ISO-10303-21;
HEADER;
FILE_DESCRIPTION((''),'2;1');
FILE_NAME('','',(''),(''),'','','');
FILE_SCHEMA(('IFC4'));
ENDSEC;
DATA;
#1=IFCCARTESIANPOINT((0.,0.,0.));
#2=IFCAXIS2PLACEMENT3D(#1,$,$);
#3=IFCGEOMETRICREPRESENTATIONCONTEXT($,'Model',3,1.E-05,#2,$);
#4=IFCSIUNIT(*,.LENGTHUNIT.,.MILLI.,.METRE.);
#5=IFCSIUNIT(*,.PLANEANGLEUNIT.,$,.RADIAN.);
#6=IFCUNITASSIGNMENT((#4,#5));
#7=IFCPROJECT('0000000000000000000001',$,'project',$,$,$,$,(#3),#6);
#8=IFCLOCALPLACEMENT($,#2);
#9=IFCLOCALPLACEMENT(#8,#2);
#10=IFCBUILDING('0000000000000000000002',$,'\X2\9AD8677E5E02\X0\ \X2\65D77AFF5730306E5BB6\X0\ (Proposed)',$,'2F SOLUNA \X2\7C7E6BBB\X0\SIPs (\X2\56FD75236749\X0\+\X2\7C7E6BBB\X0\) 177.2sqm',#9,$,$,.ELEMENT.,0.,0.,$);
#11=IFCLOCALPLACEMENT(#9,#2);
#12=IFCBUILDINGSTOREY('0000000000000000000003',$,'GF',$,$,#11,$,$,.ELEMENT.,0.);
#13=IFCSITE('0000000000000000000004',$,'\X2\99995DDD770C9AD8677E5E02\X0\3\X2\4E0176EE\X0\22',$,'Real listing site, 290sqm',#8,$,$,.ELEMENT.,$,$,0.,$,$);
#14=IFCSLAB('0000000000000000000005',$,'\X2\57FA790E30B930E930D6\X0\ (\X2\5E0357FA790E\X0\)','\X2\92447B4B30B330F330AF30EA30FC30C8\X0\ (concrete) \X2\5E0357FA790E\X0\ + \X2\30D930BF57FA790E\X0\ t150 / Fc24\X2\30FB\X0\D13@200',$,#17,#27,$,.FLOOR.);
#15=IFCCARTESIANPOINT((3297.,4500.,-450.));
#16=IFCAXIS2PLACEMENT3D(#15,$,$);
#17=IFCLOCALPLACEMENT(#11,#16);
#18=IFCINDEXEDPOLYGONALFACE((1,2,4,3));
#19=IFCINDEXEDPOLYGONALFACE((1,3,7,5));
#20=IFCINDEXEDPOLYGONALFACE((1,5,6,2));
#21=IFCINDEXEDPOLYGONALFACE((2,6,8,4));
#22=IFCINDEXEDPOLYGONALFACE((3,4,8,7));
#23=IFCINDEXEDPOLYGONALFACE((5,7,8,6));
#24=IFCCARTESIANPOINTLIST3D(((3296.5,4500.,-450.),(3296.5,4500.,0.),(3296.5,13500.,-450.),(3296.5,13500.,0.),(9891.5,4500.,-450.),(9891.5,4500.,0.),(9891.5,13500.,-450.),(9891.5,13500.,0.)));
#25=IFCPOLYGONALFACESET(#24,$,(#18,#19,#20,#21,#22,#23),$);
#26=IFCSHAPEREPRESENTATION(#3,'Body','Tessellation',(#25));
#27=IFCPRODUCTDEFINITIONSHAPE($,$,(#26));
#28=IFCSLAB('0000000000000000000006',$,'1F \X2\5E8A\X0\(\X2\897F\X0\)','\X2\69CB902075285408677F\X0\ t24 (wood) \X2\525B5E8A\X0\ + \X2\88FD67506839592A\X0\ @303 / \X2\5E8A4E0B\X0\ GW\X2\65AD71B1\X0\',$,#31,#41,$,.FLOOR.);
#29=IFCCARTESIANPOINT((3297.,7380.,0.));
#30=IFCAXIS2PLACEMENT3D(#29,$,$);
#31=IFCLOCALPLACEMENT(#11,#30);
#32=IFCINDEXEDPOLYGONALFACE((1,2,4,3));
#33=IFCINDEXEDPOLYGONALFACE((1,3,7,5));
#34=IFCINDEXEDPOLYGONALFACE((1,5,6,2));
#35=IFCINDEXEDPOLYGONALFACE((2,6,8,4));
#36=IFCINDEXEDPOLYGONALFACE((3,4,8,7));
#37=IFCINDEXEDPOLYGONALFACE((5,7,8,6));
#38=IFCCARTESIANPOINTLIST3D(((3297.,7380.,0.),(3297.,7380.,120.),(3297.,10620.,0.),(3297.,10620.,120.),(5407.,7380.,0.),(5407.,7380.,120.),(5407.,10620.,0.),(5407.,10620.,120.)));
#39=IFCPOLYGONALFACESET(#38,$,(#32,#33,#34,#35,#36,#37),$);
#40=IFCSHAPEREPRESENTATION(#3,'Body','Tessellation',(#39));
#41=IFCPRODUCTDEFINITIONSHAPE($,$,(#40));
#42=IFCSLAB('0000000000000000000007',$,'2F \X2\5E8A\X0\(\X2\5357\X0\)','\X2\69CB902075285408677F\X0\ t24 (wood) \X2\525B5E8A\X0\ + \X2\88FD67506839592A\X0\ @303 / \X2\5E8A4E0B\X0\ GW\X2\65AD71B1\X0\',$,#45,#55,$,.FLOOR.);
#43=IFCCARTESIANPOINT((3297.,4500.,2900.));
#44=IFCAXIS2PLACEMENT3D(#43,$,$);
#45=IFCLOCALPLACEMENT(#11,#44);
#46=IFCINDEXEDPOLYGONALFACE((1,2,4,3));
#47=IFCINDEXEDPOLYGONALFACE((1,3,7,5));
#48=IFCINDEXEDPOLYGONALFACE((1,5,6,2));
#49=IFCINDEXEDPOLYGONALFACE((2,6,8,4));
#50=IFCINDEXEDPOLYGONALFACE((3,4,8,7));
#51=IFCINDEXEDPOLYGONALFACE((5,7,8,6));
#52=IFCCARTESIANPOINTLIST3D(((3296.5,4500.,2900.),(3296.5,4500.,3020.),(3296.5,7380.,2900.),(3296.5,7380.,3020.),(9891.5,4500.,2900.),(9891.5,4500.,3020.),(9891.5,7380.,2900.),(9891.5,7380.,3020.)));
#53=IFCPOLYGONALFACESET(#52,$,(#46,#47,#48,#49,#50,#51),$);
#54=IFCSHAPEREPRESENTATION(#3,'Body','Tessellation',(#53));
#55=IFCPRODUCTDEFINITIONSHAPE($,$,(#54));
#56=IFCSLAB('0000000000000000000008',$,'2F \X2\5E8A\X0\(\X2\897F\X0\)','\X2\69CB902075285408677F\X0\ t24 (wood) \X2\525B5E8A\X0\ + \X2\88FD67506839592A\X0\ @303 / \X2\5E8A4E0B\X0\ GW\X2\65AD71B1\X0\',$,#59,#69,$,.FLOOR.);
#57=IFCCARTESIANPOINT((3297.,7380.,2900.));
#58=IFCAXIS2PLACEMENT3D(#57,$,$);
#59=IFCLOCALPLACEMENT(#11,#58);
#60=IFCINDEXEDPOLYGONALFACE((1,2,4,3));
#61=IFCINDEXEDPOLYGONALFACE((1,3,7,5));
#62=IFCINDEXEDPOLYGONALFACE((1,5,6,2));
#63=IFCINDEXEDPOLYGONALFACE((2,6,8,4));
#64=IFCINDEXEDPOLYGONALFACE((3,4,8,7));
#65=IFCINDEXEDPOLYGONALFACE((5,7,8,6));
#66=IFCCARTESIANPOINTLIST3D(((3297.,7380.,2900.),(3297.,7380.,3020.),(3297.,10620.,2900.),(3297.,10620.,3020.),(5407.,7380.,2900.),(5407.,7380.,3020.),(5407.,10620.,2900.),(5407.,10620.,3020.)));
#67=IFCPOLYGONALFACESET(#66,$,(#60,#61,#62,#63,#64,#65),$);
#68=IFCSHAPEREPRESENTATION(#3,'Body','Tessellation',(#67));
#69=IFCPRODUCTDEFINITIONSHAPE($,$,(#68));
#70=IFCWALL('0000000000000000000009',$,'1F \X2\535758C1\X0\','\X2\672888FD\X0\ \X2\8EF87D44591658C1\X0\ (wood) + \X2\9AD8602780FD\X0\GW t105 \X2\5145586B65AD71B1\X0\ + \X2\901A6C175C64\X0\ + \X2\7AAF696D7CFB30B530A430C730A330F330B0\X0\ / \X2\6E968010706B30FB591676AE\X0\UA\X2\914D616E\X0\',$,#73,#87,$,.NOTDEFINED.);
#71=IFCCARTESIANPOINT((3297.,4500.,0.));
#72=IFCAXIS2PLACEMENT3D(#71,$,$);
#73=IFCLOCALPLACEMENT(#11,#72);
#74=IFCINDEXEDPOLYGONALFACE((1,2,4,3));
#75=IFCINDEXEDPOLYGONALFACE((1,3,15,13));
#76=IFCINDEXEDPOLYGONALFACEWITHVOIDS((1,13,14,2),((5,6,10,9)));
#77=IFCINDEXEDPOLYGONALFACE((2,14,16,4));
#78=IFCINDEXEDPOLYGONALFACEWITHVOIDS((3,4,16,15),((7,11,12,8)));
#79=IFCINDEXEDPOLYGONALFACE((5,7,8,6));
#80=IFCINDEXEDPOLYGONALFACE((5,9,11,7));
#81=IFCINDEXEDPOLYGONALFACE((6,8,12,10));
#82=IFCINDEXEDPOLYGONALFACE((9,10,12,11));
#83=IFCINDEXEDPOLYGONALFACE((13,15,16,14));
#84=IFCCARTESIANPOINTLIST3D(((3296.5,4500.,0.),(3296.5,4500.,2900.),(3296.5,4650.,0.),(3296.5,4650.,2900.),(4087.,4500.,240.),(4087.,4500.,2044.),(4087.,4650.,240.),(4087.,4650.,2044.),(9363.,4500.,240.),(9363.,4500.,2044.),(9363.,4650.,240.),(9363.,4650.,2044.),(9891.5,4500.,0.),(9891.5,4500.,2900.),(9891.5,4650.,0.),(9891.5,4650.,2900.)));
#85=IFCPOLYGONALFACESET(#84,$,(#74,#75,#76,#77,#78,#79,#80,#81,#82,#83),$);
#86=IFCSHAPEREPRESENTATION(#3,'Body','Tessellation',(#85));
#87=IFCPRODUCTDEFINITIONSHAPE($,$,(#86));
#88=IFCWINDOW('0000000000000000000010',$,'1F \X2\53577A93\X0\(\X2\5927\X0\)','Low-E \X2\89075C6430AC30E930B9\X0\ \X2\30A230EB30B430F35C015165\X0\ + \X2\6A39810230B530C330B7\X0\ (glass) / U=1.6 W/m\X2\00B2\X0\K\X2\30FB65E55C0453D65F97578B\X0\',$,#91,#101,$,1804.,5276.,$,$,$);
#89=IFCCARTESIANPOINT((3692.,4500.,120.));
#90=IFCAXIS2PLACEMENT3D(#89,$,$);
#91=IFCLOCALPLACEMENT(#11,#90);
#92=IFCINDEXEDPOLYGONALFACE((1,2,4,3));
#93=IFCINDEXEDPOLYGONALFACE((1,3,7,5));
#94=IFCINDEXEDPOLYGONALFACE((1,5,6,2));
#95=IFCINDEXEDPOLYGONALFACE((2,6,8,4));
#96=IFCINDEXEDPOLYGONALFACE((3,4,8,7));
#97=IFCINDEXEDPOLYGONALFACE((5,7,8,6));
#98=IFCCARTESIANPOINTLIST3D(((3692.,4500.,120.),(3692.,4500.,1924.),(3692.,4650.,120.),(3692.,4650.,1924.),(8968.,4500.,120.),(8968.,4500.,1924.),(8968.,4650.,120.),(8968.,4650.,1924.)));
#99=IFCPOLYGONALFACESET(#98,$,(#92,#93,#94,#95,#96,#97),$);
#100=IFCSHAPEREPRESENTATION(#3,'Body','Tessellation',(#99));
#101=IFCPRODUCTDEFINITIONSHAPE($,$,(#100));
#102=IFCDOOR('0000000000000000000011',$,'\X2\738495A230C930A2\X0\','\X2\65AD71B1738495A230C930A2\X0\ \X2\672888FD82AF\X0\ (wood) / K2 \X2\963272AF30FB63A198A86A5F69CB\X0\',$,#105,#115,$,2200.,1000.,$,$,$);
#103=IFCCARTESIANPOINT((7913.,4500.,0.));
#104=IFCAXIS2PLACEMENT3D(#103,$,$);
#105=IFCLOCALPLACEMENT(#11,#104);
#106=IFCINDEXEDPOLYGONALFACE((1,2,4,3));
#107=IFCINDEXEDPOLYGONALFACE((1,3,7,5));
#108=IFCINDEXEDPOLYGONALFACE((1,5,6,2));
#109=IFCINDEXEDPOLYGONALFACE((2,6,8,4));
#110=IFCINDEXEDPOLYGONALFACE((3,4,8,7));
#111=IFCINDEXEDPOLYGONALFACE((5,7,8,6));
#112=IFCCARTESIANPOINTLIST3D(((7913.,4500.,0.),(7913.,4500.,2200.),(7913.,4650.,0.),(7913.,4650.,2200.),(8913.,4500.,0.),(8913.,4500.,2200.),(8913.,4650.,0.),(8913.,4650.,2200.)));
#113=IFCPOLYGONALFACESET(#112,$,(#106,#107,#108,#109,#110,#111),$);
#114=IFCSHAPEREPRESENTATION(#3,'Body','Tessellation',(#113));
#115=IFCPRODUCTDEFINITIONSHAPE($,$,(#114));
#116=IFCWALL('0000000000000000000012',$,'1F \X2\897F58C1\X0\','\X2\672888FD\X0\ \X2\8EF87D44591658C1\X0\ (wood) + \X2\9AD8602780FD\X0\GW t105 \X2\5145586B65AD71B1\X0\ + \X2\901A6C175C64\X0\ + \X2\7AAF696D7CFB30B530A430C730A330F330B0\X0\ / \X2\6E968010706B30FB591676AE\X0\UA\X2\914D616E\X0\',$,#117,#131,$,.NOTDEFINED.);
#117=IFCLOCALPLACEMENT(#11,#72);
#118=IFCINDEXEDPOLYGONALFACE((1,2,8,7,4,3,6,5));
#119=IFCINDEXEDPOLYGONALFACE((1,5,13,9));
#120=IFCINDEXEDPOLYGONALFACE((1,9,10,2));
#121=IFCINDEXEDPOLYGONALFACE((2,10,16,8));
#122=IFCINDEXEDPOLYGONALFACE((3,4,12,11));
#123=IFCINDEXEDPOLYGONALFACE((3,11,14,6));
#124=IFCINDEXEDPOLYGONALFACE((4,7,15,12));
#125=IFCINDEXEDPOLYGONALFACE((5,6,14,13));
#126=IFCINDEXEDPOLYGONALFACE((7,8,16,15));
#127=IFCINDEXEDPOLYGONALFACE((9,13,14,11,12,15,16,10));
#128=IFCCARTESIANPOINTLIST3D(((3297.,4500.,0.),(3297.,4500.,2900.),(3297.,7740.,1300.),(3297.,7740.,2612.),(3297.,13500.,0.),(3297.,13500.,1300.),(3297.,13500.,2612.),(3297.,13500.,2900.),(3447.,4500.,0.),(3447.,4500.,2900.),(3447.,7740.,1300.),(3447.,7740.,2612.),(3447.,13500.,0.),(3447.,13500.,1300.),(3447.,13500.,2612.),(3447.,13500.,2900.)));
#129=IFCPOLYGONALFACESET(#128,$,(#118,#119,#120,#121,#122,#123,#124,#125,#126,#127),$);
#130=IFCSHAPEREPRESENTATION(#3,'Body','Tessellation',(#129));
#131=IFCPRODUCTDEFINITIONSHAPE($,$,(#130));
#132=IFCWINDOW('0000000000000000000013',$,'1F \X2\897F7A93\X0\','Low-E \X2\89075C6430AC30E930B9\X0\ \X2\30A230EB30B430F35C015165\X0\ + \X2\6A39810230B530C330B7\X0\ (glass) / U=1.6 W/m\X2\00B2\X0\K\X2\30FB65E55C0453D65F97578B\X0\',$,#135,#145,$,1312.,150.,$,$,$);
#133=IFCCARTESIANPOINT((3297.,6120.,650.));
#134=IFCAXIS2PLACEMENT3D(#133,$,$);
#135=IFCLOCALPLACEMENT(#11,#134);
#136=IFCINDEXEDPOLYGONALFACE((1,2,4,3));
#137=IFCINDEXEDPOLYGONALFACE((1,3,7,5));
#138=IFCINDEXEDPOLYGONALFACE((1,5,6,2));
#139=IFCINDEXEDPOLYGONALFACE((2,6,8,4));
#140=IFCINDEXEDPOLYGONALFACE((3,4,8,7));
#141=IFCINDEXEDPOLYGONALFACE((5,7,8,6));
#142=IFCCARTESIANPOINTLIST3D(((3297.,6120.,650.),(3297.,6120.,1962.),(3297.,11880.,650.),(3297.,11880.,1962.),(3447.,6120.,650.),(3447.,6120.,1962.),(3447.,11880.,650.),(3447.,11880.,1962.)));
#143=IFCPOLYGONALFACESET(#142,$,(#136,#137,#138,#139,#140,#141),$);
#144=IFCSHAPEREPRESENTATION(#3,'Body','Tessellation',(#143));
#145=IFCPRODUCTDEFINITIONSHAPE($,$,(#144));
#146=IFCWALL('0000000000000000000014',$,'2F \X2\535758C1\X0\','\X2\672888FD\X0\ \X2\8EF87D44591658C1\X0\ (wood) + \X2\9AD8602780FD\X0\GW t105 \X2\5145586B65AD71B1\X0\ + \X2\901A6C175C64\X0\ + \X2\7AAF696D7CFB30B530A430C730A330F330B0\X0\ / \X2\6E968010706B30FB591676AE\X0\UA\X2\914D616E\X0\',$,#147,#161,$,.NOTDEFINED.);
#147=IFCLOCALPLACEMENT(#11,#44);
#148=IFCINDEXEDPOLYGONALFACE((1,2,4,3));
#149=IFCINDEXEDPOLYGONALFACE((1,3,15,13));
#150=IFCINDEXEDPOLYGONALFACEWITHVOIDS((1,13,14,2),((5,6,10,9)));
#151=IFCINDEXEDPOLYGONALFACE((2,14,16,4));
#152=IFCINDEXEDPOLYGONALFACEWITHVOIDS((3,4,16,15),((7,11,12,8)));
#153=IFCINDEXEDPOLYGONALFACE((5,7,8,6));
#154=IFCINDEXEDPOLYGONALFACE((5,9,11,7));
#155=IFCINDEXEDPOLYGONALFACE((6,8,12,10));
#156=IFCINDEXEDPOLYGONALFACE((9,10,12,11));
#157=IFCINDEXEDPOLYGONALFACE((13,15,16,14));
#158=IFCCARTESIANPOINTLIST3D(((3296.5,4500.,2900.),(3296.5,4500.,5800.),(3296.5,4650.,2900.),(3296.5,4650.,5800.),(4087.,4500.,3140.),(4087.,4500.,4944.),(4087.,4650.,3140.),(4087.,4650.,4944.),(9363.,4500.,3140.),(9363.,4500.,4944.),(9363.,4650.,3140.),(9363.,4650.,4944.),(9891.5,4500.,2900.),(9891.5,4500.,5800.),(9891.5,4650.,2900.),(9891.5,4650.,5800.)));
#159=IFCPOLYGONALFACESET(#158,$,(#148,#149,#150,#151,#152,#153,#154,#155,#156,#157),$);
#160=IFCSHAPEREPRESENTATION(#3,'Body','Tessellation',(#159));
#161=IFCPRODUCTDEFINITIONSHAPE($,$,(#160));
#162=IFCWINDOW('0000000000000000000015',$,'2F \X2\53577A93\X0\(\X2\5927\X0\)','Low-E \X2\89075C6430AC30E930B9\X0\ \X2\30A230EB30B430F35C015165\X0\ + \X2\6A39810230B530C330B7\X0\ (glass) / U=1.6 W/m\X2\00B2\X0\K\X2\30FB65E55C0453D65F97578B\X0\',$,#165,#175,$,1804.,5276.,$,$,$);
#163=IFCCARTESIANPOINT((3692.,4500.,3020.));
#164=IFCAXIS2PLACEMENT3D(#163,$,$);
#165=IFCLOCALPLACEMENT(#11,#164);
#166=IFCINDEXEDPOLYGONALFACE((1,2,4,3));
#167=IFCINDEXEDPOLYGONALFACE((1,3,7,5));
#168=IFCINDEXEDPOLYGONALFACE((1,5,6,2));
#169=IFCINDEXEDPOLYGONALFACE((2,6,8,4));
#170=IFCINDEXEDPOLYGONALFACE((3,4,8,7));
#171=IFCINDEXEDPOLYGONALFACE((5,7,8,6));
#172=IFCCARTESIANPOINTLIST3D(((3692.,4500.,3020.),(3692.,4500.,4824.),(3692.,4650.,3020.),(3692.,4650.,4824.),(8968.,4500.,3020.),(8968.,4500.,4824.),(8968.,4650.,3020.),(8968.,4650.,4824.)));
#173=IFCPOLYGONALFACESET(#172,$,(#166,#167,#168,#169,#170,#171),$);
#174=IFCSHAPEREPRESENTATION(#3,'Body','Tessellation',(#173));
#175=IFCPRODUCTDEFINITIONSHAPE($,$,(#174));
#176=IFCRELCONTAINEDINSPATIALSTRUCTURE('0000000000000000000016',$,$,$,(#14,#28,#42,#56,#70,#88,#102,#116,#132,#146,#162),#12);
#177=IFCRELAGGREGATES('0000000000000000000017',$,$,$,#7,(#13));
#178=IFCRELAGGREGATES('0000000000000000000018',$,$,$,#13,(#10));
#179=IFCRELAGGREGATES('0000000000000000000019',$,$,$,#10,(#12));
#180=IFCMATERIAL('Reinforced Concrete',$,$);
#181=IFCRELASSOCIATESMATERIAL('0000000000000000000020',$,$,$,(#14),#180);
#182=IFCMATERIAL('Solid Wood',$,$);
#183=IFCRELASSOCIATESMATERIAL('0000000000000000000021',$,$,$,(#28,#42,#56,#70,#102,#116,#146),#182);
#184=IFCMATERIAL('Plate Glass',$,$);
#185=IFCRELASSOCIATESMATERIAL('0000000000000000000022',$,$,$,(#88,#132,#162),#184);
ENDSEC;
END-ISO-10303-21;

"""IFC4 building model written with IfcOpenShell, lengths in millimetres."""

from ifc_helpers import new_model, si_unit, frame, frame_2d, origin, place, context, project, spatial, rectangle, extrude, material, element, fill, save


model = new_model("IFC4")

# Units and contexts
model_context = context("Model", 3, precision=1e-05, world=origin())
ifc_project = project(units=[si_unit("LENGTHUNIT", "METRE", prefix="MILLI"), si_unit("PLANEANGLEUNIT", "RADIAN")], contexts=[model_context])

# Site, building, storey
site_placement = place(None, origin())
site = spatial("IfcSite", under=ifc_project, at=site_placement, Name="香川県高松市3丁目22", ObjectType="Real listing site, 290sqm", CompositionType="ELEMENT", RefElevation=0.0)
building_placement = place(site_placement, origin())
building = spatial("IfcBuilding", under=site, at=building_placement, Name="高松市 旗竿地の家 (Proposed)", ObjectType="2F SOLUNA 籾殻SIPs (国産杉+籾殻) 177.2sqm", CompositionType="ELEMENT", ElevationOfRefHeight=0.0, ElevationOfTerrain=0.0)
storey_placement = place(building_placement, origin())
storey = spatial("IfcBuildingStorey", under=building, at=storey_placement, Name="GF", CompositionType="ELEMENT", Elevation=0.0)

# Slabs
ifc_material_1 = material(Name="Reinforced Concrete")
slab_1_placement = place(storey_placement, frame((3297.0, 4500.0, -450.0)))
element("IfcSlab", 1, at=slab_1_placement, inside=storey, material=ifc_material_1, Name="基礎スラブ (布基礎)", Description="鉄筋コンクリート (concrete) 布基礎 + ベタ基礎 t150 / Fc24・D13@200", PredefinedType="FLOOR", context=model_context, shape_type="SweptSolid", body=[
    extrude(rectangle(XDim=6595.0, YDim=9000.0, at=frame_2d((3297.0, 4500.0))), frame((3297.0, 4500.0, -450.0)), (0.0, 0.0, 1.0), 450.0),
])
ifc_material_2 = material(Name="Solid Wood")
slab_2_placement = place(storey_placement, frame((3297.0, 7380.0, 0.0)))
element("IfcSlab", 2, at=slab_2_placement, inside=storey, material=ifc_material_2, Name="1F 床(西)", Description="構造用合板 t24 (wood) 剛床 + 製材根太 @303 / 床下 GW断熱", PredefinedType="FLOOR", context=model_context, shape_type="SweptSolid", body=[
    extrude(rectangle(XDim=2110.0, YDim=3240.0, at=frame_2d((1055.0, 1620.0))), frame((3297.0, 7380.0, 0.0)), (0.0, 0.0, 1.0), 120.0),
])
slab_3_placement = place(storey_placement, frame((3297.0, 4500.0, 2900.0)))
element("IfcSlab", 3, at=slab_3_placement, inside=storey, material=ifc_material_2, Name="2F 床(南)", Description="構造用合板 t24 (wood) 剛床 + 製材根太 @303 / 床下 GW断熱", PredefinedType="FLOOR", context=model_context, shape_type="SweptSolid", body=[
    extrude(rectangle(XDim=6595.0, YDim=2880.0, at=frame_2d((3297.0, 1440.0))), frame((3297.0, 4500.0, 2900.0)), (0.0, 0.0, 1.0), 120.0),
])
slab_4_placement = place(storey_placement, frame((3297.0, 7380.0, 2900.0)))
element("IfcSlab", 4, at=slab_4_placement, inside=storey, material=ifc_material_2, Name="2F 床(西)", Description="構造用合板 t24 (wood) 剛床 + 製材根太 @303 / 床下 GW断熱", PredefinedType="FLOOR", context=model_context, shape_type="SweptSolid", body=[
    extrude(rectangle(XDim=2110.0, YDim=3240.0, at=frame_2d((1055.0, 1620.0))), frame((3297.0, 7380.0, 2900.0)), (0.0, 0.0, 1.0), 120.0),
])

# Wall, openings, window, door
wall_1_placement = place(storey_placement, frame((3297.0, 4500.0, 0.0)))
wall_1 = element("IfcWall", 5, at=wall_1_placement, inside=storey, material=ifc_material_2, Name="1F 南壁", Description="木製 軸組外壁 (wood) + 高性能GW t105 充填断熱 + 通気層 + 窯業系サイディング / 準耐火・外皮UA配慮", PredefinedType="NOTDEFINED", context=model_context, shape_type="SweptSolid", body=[
    extrude(rectangle(XDim=6595.0, YDim=150.0, at=frame_2d((3297.0, 75.0))), frame((3297.0, 4500.0, 0.0)), (0.0, 0.0, 1.0), 2900.0),
])
opening_1_placement = place(storey_placement, frame((3692.0, 4500.0, 120.0)))
opening_1 = element("IfcOpeningElement", 6, at=opening_1_placement, cuts=wall_1, PredefinedType="NOTDEFINED", context=model_context, shape_type="SweptSolid", body=[
    extrude(rectangle(XDim=5276.0, YDim=150.0, at=frame_2d((2638.0, 75.0))), frame((3692.0, 4500.0, 120.0)), (0.0, 0.0, 1.0), 1804.0),
])
opening_2_placement = place(storey_placement, frame((7913.0, 4500.0, 0.0)))
opening_2 = element("IfcOpeningElement", 7, at=opening_2_placement, cuts=wall_1, PredefinedType="NOTDEFINED", context=model_context, shape_type="SweptSolid", body=[
    extrude(rectangle(XDim=1000.0, YDim=150.0, at=frame_2d((500.0, 75.0))), frame((7913.0, 4500.0, 0.0)), (0.0, 0.0, 1.0), 2200.0),
])
ifc_material_3 = material(Name="Plate Glass")
window_1_placement = place(storey_placement, frame((3692.0, 4500.0, 120.0)))
window_1 = element("IfcWindow", 8, at=window_1_placement, inside=storey, material=ifc_material_3, Name="1F 南窓(大)", Description="Low-E 複層ガラス アルゴン封入 + 樹脂サッシ (glass) / U=1.6 W/m²K・日射取得型", OverallHeight=1804.0, OverallWidth=5276.0, context=model_context, shape_type="SweptSolid", body=[
    extrude(rectangle(XDim=5276.0, YDim=150.0, at=frame_2d((2638.0, 75.0))), frame((3692.0, 4500.0, 120.0)), (0.0, 0.0, 1.0), 1804.0),
])
fill(opening_1, window_1)
door_placement = place(storey_placement, frame((7913.0, 4500.0, 0.0)))
door = element("IfcDoor", 9, at=door_placement, inside=storey, material=ifc_material_2, Name="玄関ドア", Description="断熱玄関ドア 木製芯 (wood) / K2 防犯・採風機構", OverallHeight=2200.0, OverallWidth=1000.0, context=model_context, shape_type="SweptSolid", body=[
    extrude(rectangle(XDim=1000.0, YDim=150.0, at=frame_2d((500.0, 75.0))), frame((7913.0, 4500.0, 0.0)), (0.0, 0.0, 1.0), 2200.0),
])
fill(opening_2, door)

# Walls, openings, windows
wall_2_placement = place(storey_placement, frame((3297.0, 4500.0, 0.0)))
wall_2 = element("IfcWall", 10, at=wall_2_placement, inside=storey, material=ifc_material_2, Name="1F 西壁", Description="木製 軸組外壁 (wood) + 高性能GW t105 充填断熱 + 通気層 + 窯業系サイディング / 準耐火・外皮UA配慮", PredefinedType="NOTDEFINED", context=model_context, shape_type="SweptSolid", body=[
    extrude(rectangle(XDim=150.0, YDim=9000.0, at=frame_2d((75.0, 4500.0))), frame((3297.0, 4500.0, 0.0)), (0.0, 0.0, 1.0), 2900.0),
])
opening_3_placement = place(storey_placement, frame((3297.0, 6120.0, 650.0)))
opening_3 = element("IfcOpeningElement", 11, at=opening_3_placement, cuts=wall_2, PredefinedType="NOTDEFINED", context=model_context, shape_type="SweptSolid", body=[
    extrude(rectangle(XDim=150.0, YDim=5760.0, at=frame_2d((75.0, 2880.0))), frame((3297.0, 6120.0, 650.0)), (0.0, 0.0, 1.0), 1312.0),
])
window_2_placement = place(storey_placement, frame((3297.0, 6120.0, 650.0)))
window_2 = element("IfcWindow", 12, at=window_2_placement, inside=storey, material=ifc_material_3, Name="1F 西窓", Description="Low-E 複層ガラス アルゴン封入 + 樹脂サッシ (glass) / U=1.6 W/m²K・日射取得型", OverallHeight=1312.0, OverallWidth=150.0, context=model_context, shape_type="SweptSolid", body=[
    extrude(rectangle(XDim=150.0, YDim=5760.0, at=frame_2d((75.0, 2880.0))), frame((3297.0, 6120.0, 650.0)), (0.0, 0.0, 1.0), 1312.0),
])
fill(opening_3, window_2)
wall_3_placement = place(storey_placement, frame((3297.0, 4500.0, 2900.0)))
wall_3 = element("IfcWall", 13, at=wall_3_placement, inside=storey, material=ifc_material_2, Name="2F 南壁", Description="木製 軸組外壁 (wood) + 高性能GW t105 充填断熱 + 通気層 + 窯業系サイディング / 準耐火・外皮UA配慮", PredefinedType="NOTDEFINED", context=model_context, shape_type="SweptSolid", body=[
    extrude(rectangle(XDim=6595.0, YDim=150.0, at=frame_2d((3297.0, 75.0))), frame((3297.0, 4500.0, 2900.0)), (0.0, 0.0, 1.0), 2900.0),
])
opening_4_placement = place(storey_placement, frame((3692.0, 4500.0, 3020.0)))
opening_4 = element("IfcOpeningElement", 14, at=opening_4_placement, cuts=wall_3, PredefinedType="NOTDEFINED", context=model_context, shape_type="SweptSolid", body=[
    extrude(rectangle(XDim=5276.0, YDim=150.0, at=frame_2d((2638.0, 75.0))), frame((3692.0, 4500.0, 3020.0)), (0.0, 0.0, 1.0), 1804.0),
])
window_3_placement = place(storey_placement, frame((3692.0, 4500.0, 3020.0)))
window_3 = element("IfcWindow", 15, at=window_3_placement, inside=storey, material=ifc_material_3, Name="2F 南窓(大)", Description="Low-E 複層ガラス アルゴン封入 + 樹脂サッシ (glass) / U=1.6 W/m²K・日射取得型", OverallHeight=1804.0, OverallWidth=5276.0, context=model_context, shape_type="SweptSolid", body=[
    extrude(rectangle(XDim=5276.0, YDim=150.0, at=frame_2d((2638.0, 75.0))), frame((3692.0, 4500.0, 3020.0)), (0.0, 0.0, 1.0), 1804.0),
])
fill(opening_4, window_3)

save(model, "model.ifc")
